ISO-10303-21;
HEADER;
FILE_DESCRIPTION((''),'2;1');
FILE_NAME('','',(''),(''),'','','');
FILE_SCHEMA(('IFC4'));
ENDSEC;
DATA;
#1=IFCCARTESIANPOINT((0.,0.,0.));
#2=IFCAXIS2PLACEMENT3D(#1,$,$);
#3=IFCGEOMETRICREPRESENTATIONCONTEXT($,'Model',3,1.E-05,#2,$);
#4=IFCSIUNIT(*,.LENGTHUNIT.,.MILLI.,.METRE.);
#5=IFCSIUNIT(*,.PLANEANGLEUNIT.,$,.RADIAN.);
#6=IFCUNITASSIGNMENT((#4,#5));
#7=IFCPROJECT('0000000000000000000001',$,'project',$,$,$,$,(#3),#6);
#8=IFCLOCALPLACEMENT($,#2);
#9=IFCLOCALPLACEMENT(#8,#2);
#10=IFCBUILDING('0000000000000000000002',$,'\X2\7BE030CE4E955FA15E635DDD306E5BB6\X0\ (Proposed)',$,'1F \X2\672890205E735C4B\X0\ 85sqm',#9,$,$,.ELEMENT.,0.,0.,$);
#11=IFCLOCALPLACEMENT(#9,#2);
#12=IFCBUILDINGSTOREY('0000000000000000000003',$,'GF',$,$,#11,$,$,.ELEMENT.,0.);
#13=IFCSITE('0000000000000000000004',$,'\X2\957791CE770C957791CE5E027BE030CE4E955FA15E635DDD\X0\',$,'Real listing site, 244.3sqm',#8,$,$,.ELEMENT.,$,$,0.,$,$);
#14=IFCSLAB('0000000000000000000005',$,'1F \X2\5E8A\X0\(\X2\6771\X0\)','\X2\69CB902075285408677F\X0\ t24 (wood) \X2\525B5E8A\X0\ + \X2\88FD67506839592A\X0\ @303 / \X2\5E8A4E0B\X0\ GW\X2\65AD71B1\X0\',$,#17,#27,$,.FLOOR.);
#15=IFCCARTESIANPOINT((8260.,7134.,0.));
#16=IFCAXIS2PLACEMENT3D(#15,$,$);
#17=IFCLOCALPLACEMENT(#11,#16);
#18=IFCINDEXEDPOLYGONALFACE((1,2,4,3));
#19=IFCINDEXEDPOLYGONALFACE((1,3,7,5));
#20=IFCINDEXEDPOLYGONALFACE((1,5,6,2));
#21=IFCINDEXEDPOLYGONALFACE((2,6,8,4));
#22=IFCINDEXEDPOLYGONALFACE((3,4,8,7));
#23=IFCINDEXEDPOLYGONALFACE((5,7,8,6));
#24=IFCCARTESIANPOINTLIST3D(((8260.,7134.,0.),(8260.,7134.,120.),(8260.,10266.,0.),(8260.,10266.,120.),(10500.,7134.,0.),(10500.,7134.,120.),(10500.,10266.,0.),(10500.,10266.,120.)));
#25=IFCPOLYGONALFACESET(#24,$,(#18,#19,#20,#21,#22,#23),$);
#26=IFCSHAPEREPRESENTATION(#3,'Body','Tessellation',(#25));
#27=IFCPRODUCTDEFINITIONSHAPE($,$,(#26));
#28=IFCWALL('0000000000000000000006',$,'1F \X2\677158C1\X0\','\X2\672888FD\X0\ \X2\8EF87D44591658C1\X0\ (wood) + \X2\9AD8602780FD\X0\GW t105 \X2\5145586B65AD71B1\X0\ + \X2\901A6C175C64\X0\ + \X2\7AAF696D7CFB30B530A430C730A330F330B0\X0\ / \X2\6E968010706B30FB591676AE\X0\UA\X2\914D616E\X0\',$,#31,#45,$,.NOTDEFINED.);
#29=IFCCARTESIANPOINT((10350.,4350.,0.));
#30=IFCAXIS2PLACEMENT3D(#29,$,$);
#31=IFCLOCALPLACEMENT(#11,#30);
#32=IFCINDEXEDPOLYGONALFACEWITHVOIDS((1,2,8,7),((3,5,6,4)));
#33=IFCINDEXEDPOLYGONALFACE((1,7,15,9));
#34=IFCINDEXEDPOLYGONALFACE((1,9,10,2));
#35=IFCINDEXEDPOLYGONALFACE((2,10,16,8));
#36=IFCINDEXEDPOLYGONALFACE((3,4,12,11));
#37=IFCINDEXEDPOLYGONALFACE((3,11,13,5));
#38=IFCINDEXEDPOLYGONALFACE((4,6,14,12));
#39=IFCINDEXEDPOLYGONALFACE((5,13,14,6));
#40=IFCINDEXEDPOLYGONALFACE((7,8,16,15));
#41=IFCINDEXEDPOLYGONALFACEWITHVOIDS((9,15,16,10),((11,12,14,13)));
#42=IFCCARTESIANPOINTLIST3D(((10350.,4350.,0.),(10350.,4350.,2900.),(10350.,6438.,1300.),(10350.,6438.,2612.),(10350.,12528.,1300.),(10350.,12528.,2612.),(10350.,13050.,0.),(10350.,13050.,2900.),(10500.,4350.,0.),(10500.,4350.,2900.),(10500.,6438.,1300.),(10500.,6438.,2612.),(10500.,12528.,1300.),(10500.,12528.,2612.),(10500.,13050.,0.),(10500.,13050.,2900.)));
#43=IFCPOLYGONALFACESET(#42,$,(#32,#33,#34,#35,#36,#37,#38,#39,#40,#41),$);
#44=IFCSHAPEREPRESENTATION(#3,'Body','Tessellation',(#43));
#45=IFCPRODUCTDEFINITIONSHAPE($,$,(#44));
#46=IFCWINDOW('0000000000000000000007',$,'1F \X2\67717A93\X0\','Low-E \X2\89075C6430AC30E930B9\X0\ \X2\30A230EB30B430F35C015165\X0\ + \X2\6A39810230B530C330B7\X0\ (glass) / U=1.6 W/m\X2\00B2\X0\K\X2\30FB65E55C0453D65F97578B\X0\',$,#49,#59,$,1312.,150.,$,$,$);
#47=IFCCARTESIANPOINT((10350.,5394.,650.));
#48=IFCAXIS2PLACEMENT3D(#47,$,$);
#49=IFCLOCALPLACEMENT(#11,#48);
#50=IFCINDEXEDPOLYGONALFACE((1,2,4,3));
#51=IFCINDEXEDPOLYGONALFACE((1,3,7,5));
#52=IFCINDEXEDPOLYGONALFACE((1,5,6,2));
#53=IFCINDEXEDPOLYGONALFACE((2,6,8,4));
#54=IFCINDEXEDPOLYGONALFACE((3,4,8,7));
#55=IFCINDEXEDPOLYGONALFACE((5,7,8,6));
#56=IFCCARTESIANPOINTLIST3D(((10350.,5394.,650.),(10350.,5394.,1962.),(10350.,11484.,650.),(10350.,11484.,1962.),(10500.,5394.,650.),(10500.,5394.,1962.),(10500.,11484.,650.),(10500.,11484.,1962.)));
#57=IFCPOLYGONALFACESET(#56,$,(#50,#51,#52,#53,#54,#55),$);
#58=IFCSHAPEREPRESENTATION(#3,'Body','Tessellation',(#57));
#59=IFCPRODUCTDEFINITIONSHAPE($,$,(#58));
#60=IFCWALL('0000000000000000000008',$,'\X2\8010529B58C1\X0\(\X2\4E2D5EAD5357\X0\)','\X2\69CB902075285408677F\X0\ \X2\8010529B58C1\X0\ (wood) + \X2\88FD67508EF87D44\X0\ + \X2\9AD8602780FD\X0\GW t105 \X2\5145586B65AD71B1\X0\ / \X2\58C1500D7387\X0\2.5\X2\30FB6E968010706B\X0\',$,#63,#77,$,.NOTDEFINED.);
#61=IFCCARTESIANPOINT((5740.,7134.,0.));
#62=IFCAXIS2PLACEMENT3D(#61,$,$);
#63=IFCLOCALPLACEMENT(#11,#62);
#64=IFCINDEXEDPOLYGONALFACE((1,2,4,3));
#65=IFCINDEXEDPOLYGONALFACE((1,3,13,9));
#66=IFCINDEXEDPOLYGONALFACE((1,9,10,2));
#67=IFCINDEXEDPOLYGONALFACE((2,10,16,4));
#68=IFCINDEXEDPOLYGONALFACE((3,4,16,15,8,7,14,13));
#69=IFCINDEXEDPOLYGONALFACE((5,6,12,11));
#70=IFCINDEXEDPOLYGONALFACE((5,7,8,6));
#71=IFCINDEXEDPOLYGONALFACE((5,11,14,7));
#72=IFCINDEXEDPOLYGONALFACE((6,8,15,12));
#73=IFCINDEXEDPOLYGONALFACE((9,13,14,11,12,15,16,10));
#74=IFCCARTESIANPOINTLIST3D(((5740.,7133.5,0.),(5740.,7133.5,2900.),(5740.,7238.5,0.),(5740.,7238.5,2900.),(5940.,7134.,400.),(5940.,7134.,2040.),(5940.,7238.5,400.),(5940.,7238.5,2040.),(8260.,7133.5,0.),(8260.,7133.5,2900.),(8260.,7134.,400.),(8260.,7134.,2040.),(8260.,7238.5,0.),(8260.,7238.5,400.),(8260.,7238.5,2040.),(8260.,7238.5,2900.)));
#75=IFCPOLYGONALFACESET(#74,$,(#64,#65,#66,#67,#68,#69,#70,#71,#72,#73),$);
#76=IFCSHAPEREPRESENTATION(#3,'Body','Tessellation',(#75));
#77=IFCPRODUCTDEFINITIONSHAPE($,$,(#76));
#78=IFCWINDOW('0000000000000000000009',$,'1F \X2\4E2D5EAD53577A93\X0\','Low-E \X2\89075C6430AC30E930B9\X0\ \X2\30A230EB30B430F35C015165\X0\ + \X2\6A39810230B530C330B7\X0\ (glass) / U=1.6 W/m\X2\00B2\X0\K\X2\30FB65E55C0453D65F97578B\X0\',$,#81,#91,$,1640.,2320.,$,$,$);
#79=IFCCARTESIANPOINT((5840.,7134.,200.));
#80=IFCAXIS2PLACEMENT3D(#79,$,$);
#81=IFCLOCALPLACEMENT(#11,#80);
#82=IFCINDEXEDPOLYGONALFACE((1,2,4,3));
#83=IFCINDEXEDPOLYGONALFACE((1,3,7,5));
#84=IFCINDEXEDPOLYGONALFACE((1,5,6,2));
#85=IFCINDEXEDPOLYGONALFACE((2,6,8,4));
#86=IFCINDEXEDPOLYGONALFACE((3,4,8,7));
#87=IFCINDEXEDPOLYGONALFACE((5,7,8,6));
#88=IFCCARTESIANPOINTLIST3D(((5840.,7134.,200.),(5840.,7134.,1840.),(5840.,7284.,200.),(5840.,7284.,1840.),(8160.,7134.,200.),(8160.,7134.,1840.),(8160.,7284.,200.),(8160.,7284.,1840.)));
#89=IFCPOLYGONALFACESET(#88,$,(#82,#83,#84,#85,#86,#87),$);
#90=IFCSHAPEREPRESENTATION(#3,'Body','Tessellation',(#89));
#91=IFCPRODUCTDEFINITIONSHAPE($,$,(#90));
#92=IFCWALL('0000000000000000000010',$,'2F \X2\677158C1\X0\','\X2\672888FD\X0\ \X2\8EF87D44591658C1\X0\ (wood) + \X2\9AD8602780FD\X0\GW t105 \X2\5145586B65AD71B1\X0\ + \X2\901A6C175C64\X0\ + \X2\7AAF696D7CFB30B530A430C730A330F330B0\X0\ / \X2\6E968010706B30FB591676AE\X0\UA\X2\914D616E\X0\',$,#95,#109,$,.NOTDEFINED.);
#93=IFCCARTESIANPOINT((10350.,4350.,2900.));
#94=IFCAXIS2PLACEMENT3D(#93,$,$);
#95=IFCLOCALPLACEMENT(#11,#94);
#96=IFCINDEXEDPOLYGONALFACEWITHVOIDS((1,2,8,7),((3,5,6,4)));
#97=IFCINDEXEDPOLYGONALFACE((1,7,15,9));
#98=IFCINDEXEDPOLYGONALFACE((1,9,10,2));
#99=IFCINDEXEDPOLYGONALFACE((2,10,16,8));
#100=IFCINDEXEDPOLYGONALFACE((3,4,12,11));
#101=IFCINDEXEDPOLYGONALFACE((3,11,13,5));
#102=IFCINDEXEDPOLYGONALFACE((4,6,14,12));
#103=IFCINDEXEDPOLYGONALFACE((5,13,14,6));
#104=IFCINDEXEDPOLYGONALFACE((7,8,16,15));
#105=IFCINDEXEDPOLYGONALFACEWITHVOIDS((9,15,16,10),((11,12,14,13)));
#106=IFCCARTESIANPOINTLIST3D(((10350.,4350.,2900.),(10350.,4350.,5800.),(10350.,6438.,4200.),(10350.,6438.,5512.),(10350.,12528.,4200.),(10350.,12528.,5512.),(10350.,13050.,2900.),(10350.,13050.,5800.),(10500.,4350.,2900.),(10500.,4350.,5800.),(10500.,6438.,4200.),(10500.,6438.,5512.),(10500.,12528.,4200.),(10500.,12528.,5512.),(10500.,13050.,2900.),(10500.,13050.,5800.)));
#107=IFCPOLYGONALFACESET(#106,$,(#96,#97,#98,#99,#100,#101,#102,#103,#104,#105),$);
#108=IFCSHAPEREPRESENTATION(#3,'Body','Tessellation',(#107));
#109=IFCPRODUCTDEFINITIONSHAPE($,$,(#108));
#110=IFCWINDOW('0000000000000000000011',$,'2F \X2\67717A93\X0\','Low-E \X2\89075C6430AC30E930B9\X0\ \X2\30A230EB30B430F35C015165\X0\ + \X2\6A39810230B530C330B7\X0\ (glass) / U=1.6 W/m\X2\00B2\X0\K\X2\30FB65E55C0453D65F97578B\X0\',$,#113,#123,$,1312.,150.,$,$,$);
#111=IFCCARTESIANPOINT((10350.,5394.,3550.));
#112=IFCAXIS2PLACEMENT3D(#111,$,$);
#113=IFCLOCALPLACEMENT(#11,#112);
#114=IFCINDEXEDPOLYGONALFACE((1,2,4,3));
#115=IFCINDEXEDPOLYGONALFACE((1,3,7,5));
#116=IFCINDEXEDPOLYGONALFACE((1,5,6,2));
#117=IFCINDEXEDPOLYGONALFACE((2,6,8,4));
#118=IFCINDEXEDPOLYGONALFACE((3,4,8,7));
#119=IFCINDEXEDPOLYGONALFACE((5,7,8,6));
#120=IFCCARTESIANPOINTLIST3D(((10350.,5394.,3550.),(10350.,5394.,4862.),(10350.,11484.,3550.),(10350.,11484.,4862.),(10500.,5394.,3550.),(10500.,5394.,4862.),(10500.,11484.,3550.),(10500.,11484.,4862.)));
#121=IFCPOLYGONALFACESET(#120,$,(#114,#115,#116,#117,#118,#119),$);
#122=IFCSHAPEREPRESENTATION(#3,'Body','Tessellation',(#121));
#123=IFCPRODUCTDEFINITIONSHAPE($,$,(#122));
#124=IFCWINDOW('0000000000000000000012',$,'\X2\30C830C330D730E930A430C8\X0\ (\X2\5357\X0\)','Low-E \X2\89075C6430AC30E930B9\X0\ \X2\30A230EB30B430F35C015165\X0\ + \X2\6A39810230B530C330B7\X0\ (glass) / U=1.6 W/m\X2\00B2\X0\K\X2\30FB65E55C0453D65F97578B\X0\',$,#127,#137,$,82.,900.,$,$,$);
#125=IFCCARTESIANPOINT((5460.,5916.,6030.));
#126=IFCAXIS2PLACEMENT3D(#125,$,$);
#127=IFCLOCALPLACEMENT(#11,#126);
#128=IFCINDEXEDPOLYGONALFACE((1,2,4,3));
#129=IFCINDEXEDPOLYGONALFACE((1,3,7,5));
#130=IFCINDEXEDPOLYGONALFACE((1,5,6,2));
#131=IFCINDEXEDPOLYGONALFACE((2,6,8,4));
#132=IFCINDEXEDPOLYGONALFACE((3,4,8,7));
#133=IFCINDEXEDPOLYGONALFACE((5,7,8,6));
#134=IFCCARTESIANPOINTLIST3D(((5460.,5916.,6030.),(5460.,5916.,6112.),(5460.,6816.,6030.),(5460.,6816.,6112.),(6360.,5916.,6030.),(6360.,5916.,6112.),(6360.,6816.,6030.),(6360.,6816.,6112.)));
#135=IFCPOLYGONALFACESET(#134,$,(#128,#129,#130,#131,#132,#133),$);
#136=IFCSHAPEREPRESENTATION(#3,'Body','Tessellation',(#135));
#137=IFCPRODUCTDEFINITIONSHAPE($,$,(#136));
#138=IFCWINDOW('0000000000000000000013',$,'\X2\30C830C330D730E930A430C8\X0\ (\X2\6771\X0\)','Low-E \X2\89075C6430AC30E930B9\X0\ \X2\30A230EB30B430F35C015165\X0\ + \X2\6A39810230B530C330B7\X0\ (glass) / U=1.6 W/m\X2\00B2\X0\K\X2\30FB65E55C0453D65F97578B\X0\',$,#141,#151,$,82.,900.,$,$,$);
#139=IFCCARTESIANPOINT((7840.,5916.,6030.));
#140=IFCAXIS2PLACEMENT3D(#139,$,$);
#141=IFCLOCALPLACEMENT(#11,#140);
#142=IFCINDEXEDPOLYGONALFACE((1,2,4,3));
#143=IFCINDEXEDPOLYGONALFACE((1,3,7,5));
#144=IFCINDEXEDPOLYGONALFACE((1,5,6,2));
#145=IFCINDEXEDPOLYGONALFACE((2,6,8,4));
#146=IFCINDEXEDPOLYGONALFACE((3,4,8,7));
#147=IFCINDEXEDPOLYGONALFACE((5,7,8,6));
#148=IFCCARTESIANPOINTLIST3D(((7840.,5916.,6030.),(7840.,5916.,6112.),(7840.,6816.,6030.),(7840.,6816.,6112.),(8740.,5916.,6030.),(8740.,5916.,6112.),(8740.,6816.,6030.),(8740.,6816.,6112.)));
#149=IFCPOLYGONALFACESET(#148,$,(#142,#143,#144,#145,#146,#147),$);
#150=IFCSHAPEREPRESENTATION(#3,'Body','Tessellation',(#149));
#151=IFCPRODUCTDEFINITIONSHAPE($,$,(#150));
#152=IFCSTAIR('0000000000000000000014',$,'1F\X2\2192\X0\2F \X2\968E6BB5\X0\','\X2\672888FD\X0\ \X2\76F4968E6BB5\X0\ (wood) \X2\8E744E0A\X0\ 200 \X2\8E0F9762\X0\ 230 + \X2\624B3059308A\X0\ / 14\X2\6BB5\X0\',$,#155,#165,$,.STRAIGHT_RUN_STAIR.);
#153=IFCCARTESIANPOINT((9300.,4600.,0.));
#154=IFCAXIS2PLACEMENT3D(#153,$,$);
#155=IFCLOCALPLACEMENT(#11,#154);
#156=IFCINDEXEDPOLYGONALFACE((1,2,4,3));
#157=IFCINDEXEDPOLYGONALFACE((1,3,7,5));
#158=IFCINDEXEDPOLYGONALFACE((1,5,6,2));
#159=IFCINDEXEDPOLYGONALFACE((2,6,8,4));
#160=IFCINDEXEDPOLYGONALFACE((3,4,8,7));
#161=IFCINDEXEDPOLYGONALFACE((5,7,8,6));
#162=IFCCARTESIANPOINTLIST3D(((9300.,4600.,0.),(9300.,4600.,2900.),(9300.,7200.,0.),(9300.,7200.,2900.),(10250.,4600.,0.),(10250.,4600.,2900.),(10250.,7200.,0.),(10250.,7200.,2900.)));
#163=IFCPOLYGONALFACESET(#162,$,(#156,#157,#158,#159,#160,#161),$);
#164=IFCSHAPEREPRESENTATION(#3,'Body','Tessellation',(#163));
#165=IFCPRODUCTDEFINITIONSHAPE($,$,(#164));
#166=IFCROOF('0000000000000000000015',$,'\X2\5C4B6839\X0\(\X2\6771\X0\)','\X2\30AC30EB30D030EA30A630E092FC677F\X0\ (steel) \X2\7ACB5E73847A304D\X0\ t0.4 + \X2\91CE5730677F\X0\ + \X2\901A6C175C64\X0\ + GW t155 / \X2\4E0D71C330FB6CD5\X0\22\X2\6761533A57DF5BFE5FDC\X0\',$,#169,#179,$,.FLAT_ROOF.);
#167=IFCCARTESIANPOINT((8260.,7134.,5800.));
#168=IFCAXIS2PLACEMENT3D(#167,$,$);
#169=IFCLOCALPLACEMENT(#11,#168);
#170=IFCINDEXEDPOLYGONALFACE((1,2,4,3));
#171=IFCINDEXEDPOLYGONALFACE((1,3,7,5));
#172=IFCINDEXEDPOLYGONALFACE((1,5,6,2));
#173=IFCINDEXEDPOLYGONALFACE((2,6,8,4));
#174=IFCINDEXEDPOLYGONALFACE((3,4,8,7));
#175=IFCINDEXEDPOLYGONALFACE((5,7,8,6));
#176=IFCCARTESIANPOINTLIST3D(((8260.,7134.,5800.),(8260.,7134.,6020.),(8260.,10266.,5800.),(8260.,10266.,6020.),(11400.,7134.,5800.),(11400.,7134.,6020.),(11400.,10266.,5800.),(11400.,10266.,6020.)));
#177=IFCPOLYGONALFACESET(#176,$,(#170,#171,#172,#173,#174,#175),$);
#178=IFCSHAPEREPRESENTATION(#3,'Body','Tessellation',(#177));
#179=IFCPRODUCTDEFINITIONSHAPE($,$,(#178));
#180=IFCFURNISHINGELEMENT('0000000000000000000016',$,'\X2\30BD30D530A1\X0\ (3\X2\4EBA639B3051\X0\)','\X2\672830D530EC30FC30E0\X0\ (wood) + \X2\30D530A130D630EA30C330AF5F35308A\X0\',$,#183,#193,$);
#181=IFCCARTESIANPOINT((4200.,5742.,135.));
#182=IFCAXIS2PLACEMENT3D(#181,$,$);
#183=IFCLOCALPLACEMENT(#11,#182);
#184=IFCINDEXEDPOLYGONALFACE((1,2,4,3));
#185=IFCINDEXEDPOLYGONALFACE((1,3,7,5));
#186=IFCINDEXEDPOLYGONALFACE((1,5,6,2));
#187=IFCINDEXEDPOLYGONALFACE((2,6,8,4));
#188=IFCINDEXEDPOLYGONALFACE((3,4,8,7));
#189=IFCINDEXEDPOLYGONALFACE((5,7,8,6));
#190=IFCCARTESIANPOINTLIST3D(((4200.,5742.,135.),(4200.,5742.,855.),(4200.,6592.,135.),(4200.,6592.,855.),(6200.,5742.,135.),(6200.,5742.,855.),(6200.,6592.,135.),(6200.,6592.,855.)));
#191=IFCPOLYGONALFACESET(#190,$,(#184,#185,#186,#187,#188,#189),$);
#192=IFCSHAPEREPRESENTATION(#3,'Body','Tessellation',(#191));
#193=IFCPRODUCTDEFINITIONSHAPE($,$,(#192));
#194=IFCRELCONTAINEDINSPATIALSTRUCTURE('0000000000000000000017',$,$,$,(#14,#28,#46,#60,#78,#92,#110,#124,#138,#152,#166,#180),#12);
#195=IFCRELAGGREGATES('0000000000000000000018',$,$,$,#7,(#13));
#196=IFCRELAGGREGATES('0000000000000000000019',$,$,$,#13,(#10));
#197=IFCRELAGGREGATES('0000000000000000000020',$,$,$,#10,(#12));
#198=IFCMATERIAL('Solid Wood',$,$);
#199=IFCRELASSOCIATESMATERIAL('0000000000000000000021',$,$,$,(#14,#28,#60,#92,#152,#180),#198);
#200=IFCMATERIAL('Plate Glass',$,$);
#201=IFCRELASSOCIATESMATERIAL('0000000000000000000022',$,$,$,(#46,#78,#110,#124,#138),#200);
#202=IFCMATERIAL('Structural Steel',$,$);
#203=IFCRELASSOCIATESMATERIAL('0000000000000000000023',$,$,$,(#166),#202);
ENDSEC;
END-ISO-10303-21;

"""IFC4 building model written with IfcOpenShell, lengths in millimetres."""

from ifc_helpers import new_model, si_unit, frame, frame_2d, origin, place, context, project, spatial, rectangle, extrude, material, element, fill, save


model = new_model("IFC4")

# Units and contexts
model_context = context("Model", 3, precision=1e-05, world=origin())
ifc_project = project(units=[si_unit("LENGTHUNIT", "METRE", prefix="MILLI"), si_unit("PLANEANGLEUNIT", "RADIAN")], contexts=[model_context])

# Site, building, storey
site_placement = place(None, origin())
site = spatial("IfcSite", under=ifc_project, at=site_placement, Name="長野県長野市篠ノ井御幣川", ObjectType="Real listing site, 244.3sqm", CompositionType="ELEMENT", RefElevation=0.0)
building_placement = place(site_placement, origin())
building = spatial("IfcBuilding", under=site, at=building_placement, Name="篠ノ井御幣川の家 (Proposed)", ObjectType="1F 木造平屋 85sqm", CompositionType="ELEMENT", ElevationOfRefHeight=0.0, ElevationOfTerrain=0.0)
storey_placement = place(building_placement, origin())
storey = spatial("IfcBuildingStorey", under=building, at=storey_placement, Name="GF", CompositionType="ELEMENT", Elevation=0.0)

# Slab
ifc_material_1 = material(Name="Solid Wood")
slab_placement = place(storey_placement, frame((8260.0, 7134.0, 0.0)))
element("IfcSlab", 1, at=slab_placement, inside=storey, material=ifc_material_1, Name="1F 床(東)", Description="構造用合板 t24 (wood) 剛床 + 製材根太 @303 / 床下 GW断熱", PredefinedType="FLOOR", context=model_context, shape_type="SweptSolid", body=[
    extrude(rectangle(XDim=2240.0, YDim=3132.0, at=frame_2d((1120.0, 1566.0))), frame((8260.0, 7134.0, 0.0)), (0.0, 0.0, 1.0), 120.0),
])

# Walls, openings, windows
wall_1_placement = place(storey_placement, frame((10350.0, 4350.0, 0.0)))
wall_1 = element("IfcWall", 2, at=wall_1_placement, inside=storey, material=ifc_material_1, Name="1F 東壁", Description="木製 軸組外壁 (wood) + 高性能GW t105 充填断熱 + 通気層 + 窯業系サイディング / 準耐火・外皮UA配慮", PredefinedType="NOTDEFINED", context=model_context, shape_type="SweptSolid", body=[
    extrude(rectangle(XDim=150.0, YDim=8700.0, at=frame_2d((75.0, 4350.0))), frame((10350.0, 4350.0, 0.0)), (0.0, 0.0, 1.0), 2900.0),
])
opening_1_placement = place(storey_placement, frame((10350.0, 5394.0, 650.0)))
opening_1 = element("IfcOpeningElement", 3, at=opening_1_placement, cuts=wall_1, PredefinedType="NOTDEFINED", context=model_context, shape_type="SweptSolid", body=[
    extrude(rectangle(XDim=150.0, YDim=6090.0, at=frame_2d((75.0, 3045.0))), frame((10350.0, 5394.0, 650.0)), (0.0, 0.0, 1.0), 1312.0),
])
ifc_material_2 = material(Name="Plate Glass")
window_1_placement = place(storey_placement, frame((10350.0, 5394.0, 650.0)))
window_1 = element("IfcWindow", 4, at=window_1_placement, inside=storey, material=ifc_material_2, Name="1F 東窓", Description="Low-E 複層ガラス アルゴン封入 + 樹脂サッシ (glass) / U=1.6 W/m²K・日射取得型", OverallHeight=1312.0, OverallWidth=150.0, context=model_context, shape_type="SweptSolid", body=[
    extrude(rectangle(XDim=150.0, YDim=6090.0, at=frame_2d((75.0, 3045.0))), frame((10350.0, 5394.0, 650.0)), (0.0, 0.0, 1.0), 1312.0),
])
fill(opening_1, window_1)
wall_2_placement = place(storey_placement, frame((5740.0, 7134.0, 0.0)))
wall_2 = element("IfcWall", 5, at=wall_2_placement, inside=storey, material=ifc_material_1, Name="耐力壁(中庭南)", Description="構造用合板 耐力壁 (wood) + 製材軸組 + 高性能GW t105 充填断熱 / 壁倍率2.5・準耐火", PredefinedType="NOTDEFINED", context=model_context, shape_type="SweptSolid", body=[
    extrude(rectangle(XDim=2520.0, YDim=105.0, at=frame_2d((1260.0, 52.0))), frame((5740.0, 7134.0, 0.0)), (0.0, 0.0, 1.0), 2900.0),
])
opening_2_placement = place(storey_placement, frame((5840.0, 7134.0, 200.0)))
opening_2 = element("IfcOpeningElement", 6, at=opening_2_placement, cuts=wall_2, PredefinedType="NOTDEFINED", context=model_context, shape_type="SweptSolid", body=[
    extrude(rectangle(XDim=2320.0, YDim=150.0, at=frame_2d((1160.0, 75.0))), frame((5840.0, 7134.0, 200.0)), (0.0, 0.0, 1.0), 1640.0),
])
window_2_placement = place(storey_placement, frame((5840.0, 7134.0, 200.0)))
window_2 = element("IfcWindow", 7, at=window_2_placement, inside=storey, material=ifc_material_2, Name="1F 中庭南窓", Description="Low-E 複層ガラス アルゴン封入 + 樹脂サッシ (glass) / U=1.6 W/m²K・日射取得型", OverallHeight=1640.0, OverallWidth=2320.0, context=model_context, shape_type="SweptSolid", body=[
    extrude(rectangle(XDim=2320.0, YDim=150.0, at=frame_2d((1160.0, 75.0))), frame((5840.0, 7134.0, 200.0)), (0.0, 0.0, 1.0), 1640.0),
])
fill(opening_2, window_2)

# Wall, opening, window
wall_3_placement = place(storey_placement, frame((10350.0, 4350.0, 2900.0)))
wall_3 = element("IfcWall", 8, at=wall_3_placement, inside=storey, material=ifc_material_1, Name="2F 東壁", Description="木製 軸組外壁 (wood) + 高性能GW t105 充填断熱 + 通気層 + 窯業系サイディング / 準耐火・外皮UA配慮", PredefinedType="NOTDEFINED", context=model_context, shape_type="SweptSolid", body=[
    extrude(rectangle(XDim=150.0, YDim=8700.0, at=frame_2d((75.0, 4350.0))), frame((10350.0, 4350.0, 2900.0)), (0.0, 0.0, 1.0), 2900.0),
])
opening_3_placement = place(storey_placement, frame((10350.0, 5394.0, 3550.0)))
opening_3 = element("IfcOpeningElement", 9, at=opening_3_placement, cuts=wall_3, PredefinedType="NOTDEFINED", context=model_context, shape_type="SweptSolid", body=[
    extrude(rectangle(XDim=150.0, YDim=6090.0, at=frame_2d((75.0, 3045.0))), frame((10350.0, 5394.0, 3550.0)), (0.0, 0.0, 1.0), 1312.0),
])
window_3_placement = place(storey_placement, frame((10350.0, 5394.0, 3550.0)))
window_3 = element("IfcWindow", 10, at=window_3_placement, inside=storey, material=ifc_material_2, Name="2F 東窓", Description="Low-E 複層ガラス アルゴン封入 + 樹脂サッシ (glass) / U=1.6 W/m²K・日射取得型", OverallHeight=1312.0, OverallWidth=150.0, context=model_context, shape_type="SweptSolid", body=[
    extrude(rectangle(XDim=150.0, YDim=6090.0, at=frame_2d((75.0, 3045.0))), frame((10350.0, 5394.0, 3550.0)), (0.0, 0.0, 1.0), 1312.0),
])
fill(opening_3, window_3)

# Windows
window_4_placement = place(storey_placement, frame((5460.0, 5916.0, 6030.0)))
element("IfcWindow", 11, at=window_4_placement, inside=storey, material=ifc_material_2, Name="トップライト (南)", Description="Low-E 複層ガラス アルゴン封入 + 樹脂サッシ (glass) / U=1.6 W/m²K・日射取得型", OverallHeight=82.0, OverallWidth=900.0, context=model_context, shape_type="SweptSolid", body=[
    extrude(rectangle(XDim=900.0, YDim=900.0, at=frame_2d((450.0, 450.0))), frame((5460.0, 5916.0, 6030.0)), (0.0, 0.0, 1.0), 82.0),
])
window_5_placement = place(storey_placement, frame((7840.0, 5916.0, 6030.0)))
element("IfcWindow", 12, at=window_5_placement, inside=storey, material=ifc_material_2, Name="トップライト (東)", Description="Low-E 複層ガラス アルゴン封入 + 樹脂サッシ (glass) / U=1.6 W/m²K・日射取得型", OverallHeight=82.0, OverallWidth=900.0, context=model_context, shape_type="SweptSolid", body=[
    extrude(rectangle(XDim=900.0, YDim=900.0, at=frame_2d((450.0, 450.0))), frame((7840.0, 5916.0, 6030.0)), (0.0, 0.0, 1.0), 82.0),
])

# Stair
stair_placement = place(storey_placement, frame((9300.0, 4600.0, 0.0)))
element("IfcStair", 13, at=stair_placement, inside=storey, material=ifc_material_1, Name="1F→2F 階段", Description="木製 直階段 (wood) 蹴上 200 踏面 230 + 手すり / 14段", PredefinedType="STRAIGHT_RUN_STAIR", context=model_context, shape_type="SweptSolid", body=[
    extrude(rectangle(XDim=950.0, YDim=2600.0, at=frame_2d((475.0, 1300.0))), frame((9300.0, 4600.0, 0.0)), (0.0, 0.0, 1.0), 2900.0),
])

# Roof
ifc_material_3 = material(Name="Structural Steel")
roof_placement = place(storey_placement, frame((8260.0, 7134.0, 5800.0)))
element("IfcRoof", 14, at=roof_placement, inside=storey, material=ifc_material_3, Name="屋根(東)", Description="ガルバリウム鋼板 (steel) 立平葺き t0.4 + 野地板 + 通気層 + GW t155 / 不燃・法22条区域対応", PredefinedType="FLAT_ROOF", context=model_context, shape_type="SweptSolid", body=[
    extrude(rectangle(XDim=3140.0, YDim=3132.0, at=frame_2d((1570.0, 1566.0))), frame((8260.0, 7134.0, 5800.0)), (0.0, 0.0, 1.0), 220.0),
])

# Furnishing element
furnishing_1_placement = place(storey_placement, frame((4200.0, 5742.0, 135.0)))
element("IfcFurnishingElement", 15, at=furnishing_1_placement, inside=storey, material=ifc_material_1, Name="ソファ (3人掛け)", Description="木フレーム (wood) + ファブリック張り", context=model_context, shape_type="SweptSolid", body=[
    extrude(rectangle(XDim=2000.0, YDim=850.0, at=frame_2d((1000.0, 425.0))), frame((4200.0, 5742.0, 135.0)), (0.0, 0.0, 1.0), 720.0),
])

save(model, "model.ifc")
